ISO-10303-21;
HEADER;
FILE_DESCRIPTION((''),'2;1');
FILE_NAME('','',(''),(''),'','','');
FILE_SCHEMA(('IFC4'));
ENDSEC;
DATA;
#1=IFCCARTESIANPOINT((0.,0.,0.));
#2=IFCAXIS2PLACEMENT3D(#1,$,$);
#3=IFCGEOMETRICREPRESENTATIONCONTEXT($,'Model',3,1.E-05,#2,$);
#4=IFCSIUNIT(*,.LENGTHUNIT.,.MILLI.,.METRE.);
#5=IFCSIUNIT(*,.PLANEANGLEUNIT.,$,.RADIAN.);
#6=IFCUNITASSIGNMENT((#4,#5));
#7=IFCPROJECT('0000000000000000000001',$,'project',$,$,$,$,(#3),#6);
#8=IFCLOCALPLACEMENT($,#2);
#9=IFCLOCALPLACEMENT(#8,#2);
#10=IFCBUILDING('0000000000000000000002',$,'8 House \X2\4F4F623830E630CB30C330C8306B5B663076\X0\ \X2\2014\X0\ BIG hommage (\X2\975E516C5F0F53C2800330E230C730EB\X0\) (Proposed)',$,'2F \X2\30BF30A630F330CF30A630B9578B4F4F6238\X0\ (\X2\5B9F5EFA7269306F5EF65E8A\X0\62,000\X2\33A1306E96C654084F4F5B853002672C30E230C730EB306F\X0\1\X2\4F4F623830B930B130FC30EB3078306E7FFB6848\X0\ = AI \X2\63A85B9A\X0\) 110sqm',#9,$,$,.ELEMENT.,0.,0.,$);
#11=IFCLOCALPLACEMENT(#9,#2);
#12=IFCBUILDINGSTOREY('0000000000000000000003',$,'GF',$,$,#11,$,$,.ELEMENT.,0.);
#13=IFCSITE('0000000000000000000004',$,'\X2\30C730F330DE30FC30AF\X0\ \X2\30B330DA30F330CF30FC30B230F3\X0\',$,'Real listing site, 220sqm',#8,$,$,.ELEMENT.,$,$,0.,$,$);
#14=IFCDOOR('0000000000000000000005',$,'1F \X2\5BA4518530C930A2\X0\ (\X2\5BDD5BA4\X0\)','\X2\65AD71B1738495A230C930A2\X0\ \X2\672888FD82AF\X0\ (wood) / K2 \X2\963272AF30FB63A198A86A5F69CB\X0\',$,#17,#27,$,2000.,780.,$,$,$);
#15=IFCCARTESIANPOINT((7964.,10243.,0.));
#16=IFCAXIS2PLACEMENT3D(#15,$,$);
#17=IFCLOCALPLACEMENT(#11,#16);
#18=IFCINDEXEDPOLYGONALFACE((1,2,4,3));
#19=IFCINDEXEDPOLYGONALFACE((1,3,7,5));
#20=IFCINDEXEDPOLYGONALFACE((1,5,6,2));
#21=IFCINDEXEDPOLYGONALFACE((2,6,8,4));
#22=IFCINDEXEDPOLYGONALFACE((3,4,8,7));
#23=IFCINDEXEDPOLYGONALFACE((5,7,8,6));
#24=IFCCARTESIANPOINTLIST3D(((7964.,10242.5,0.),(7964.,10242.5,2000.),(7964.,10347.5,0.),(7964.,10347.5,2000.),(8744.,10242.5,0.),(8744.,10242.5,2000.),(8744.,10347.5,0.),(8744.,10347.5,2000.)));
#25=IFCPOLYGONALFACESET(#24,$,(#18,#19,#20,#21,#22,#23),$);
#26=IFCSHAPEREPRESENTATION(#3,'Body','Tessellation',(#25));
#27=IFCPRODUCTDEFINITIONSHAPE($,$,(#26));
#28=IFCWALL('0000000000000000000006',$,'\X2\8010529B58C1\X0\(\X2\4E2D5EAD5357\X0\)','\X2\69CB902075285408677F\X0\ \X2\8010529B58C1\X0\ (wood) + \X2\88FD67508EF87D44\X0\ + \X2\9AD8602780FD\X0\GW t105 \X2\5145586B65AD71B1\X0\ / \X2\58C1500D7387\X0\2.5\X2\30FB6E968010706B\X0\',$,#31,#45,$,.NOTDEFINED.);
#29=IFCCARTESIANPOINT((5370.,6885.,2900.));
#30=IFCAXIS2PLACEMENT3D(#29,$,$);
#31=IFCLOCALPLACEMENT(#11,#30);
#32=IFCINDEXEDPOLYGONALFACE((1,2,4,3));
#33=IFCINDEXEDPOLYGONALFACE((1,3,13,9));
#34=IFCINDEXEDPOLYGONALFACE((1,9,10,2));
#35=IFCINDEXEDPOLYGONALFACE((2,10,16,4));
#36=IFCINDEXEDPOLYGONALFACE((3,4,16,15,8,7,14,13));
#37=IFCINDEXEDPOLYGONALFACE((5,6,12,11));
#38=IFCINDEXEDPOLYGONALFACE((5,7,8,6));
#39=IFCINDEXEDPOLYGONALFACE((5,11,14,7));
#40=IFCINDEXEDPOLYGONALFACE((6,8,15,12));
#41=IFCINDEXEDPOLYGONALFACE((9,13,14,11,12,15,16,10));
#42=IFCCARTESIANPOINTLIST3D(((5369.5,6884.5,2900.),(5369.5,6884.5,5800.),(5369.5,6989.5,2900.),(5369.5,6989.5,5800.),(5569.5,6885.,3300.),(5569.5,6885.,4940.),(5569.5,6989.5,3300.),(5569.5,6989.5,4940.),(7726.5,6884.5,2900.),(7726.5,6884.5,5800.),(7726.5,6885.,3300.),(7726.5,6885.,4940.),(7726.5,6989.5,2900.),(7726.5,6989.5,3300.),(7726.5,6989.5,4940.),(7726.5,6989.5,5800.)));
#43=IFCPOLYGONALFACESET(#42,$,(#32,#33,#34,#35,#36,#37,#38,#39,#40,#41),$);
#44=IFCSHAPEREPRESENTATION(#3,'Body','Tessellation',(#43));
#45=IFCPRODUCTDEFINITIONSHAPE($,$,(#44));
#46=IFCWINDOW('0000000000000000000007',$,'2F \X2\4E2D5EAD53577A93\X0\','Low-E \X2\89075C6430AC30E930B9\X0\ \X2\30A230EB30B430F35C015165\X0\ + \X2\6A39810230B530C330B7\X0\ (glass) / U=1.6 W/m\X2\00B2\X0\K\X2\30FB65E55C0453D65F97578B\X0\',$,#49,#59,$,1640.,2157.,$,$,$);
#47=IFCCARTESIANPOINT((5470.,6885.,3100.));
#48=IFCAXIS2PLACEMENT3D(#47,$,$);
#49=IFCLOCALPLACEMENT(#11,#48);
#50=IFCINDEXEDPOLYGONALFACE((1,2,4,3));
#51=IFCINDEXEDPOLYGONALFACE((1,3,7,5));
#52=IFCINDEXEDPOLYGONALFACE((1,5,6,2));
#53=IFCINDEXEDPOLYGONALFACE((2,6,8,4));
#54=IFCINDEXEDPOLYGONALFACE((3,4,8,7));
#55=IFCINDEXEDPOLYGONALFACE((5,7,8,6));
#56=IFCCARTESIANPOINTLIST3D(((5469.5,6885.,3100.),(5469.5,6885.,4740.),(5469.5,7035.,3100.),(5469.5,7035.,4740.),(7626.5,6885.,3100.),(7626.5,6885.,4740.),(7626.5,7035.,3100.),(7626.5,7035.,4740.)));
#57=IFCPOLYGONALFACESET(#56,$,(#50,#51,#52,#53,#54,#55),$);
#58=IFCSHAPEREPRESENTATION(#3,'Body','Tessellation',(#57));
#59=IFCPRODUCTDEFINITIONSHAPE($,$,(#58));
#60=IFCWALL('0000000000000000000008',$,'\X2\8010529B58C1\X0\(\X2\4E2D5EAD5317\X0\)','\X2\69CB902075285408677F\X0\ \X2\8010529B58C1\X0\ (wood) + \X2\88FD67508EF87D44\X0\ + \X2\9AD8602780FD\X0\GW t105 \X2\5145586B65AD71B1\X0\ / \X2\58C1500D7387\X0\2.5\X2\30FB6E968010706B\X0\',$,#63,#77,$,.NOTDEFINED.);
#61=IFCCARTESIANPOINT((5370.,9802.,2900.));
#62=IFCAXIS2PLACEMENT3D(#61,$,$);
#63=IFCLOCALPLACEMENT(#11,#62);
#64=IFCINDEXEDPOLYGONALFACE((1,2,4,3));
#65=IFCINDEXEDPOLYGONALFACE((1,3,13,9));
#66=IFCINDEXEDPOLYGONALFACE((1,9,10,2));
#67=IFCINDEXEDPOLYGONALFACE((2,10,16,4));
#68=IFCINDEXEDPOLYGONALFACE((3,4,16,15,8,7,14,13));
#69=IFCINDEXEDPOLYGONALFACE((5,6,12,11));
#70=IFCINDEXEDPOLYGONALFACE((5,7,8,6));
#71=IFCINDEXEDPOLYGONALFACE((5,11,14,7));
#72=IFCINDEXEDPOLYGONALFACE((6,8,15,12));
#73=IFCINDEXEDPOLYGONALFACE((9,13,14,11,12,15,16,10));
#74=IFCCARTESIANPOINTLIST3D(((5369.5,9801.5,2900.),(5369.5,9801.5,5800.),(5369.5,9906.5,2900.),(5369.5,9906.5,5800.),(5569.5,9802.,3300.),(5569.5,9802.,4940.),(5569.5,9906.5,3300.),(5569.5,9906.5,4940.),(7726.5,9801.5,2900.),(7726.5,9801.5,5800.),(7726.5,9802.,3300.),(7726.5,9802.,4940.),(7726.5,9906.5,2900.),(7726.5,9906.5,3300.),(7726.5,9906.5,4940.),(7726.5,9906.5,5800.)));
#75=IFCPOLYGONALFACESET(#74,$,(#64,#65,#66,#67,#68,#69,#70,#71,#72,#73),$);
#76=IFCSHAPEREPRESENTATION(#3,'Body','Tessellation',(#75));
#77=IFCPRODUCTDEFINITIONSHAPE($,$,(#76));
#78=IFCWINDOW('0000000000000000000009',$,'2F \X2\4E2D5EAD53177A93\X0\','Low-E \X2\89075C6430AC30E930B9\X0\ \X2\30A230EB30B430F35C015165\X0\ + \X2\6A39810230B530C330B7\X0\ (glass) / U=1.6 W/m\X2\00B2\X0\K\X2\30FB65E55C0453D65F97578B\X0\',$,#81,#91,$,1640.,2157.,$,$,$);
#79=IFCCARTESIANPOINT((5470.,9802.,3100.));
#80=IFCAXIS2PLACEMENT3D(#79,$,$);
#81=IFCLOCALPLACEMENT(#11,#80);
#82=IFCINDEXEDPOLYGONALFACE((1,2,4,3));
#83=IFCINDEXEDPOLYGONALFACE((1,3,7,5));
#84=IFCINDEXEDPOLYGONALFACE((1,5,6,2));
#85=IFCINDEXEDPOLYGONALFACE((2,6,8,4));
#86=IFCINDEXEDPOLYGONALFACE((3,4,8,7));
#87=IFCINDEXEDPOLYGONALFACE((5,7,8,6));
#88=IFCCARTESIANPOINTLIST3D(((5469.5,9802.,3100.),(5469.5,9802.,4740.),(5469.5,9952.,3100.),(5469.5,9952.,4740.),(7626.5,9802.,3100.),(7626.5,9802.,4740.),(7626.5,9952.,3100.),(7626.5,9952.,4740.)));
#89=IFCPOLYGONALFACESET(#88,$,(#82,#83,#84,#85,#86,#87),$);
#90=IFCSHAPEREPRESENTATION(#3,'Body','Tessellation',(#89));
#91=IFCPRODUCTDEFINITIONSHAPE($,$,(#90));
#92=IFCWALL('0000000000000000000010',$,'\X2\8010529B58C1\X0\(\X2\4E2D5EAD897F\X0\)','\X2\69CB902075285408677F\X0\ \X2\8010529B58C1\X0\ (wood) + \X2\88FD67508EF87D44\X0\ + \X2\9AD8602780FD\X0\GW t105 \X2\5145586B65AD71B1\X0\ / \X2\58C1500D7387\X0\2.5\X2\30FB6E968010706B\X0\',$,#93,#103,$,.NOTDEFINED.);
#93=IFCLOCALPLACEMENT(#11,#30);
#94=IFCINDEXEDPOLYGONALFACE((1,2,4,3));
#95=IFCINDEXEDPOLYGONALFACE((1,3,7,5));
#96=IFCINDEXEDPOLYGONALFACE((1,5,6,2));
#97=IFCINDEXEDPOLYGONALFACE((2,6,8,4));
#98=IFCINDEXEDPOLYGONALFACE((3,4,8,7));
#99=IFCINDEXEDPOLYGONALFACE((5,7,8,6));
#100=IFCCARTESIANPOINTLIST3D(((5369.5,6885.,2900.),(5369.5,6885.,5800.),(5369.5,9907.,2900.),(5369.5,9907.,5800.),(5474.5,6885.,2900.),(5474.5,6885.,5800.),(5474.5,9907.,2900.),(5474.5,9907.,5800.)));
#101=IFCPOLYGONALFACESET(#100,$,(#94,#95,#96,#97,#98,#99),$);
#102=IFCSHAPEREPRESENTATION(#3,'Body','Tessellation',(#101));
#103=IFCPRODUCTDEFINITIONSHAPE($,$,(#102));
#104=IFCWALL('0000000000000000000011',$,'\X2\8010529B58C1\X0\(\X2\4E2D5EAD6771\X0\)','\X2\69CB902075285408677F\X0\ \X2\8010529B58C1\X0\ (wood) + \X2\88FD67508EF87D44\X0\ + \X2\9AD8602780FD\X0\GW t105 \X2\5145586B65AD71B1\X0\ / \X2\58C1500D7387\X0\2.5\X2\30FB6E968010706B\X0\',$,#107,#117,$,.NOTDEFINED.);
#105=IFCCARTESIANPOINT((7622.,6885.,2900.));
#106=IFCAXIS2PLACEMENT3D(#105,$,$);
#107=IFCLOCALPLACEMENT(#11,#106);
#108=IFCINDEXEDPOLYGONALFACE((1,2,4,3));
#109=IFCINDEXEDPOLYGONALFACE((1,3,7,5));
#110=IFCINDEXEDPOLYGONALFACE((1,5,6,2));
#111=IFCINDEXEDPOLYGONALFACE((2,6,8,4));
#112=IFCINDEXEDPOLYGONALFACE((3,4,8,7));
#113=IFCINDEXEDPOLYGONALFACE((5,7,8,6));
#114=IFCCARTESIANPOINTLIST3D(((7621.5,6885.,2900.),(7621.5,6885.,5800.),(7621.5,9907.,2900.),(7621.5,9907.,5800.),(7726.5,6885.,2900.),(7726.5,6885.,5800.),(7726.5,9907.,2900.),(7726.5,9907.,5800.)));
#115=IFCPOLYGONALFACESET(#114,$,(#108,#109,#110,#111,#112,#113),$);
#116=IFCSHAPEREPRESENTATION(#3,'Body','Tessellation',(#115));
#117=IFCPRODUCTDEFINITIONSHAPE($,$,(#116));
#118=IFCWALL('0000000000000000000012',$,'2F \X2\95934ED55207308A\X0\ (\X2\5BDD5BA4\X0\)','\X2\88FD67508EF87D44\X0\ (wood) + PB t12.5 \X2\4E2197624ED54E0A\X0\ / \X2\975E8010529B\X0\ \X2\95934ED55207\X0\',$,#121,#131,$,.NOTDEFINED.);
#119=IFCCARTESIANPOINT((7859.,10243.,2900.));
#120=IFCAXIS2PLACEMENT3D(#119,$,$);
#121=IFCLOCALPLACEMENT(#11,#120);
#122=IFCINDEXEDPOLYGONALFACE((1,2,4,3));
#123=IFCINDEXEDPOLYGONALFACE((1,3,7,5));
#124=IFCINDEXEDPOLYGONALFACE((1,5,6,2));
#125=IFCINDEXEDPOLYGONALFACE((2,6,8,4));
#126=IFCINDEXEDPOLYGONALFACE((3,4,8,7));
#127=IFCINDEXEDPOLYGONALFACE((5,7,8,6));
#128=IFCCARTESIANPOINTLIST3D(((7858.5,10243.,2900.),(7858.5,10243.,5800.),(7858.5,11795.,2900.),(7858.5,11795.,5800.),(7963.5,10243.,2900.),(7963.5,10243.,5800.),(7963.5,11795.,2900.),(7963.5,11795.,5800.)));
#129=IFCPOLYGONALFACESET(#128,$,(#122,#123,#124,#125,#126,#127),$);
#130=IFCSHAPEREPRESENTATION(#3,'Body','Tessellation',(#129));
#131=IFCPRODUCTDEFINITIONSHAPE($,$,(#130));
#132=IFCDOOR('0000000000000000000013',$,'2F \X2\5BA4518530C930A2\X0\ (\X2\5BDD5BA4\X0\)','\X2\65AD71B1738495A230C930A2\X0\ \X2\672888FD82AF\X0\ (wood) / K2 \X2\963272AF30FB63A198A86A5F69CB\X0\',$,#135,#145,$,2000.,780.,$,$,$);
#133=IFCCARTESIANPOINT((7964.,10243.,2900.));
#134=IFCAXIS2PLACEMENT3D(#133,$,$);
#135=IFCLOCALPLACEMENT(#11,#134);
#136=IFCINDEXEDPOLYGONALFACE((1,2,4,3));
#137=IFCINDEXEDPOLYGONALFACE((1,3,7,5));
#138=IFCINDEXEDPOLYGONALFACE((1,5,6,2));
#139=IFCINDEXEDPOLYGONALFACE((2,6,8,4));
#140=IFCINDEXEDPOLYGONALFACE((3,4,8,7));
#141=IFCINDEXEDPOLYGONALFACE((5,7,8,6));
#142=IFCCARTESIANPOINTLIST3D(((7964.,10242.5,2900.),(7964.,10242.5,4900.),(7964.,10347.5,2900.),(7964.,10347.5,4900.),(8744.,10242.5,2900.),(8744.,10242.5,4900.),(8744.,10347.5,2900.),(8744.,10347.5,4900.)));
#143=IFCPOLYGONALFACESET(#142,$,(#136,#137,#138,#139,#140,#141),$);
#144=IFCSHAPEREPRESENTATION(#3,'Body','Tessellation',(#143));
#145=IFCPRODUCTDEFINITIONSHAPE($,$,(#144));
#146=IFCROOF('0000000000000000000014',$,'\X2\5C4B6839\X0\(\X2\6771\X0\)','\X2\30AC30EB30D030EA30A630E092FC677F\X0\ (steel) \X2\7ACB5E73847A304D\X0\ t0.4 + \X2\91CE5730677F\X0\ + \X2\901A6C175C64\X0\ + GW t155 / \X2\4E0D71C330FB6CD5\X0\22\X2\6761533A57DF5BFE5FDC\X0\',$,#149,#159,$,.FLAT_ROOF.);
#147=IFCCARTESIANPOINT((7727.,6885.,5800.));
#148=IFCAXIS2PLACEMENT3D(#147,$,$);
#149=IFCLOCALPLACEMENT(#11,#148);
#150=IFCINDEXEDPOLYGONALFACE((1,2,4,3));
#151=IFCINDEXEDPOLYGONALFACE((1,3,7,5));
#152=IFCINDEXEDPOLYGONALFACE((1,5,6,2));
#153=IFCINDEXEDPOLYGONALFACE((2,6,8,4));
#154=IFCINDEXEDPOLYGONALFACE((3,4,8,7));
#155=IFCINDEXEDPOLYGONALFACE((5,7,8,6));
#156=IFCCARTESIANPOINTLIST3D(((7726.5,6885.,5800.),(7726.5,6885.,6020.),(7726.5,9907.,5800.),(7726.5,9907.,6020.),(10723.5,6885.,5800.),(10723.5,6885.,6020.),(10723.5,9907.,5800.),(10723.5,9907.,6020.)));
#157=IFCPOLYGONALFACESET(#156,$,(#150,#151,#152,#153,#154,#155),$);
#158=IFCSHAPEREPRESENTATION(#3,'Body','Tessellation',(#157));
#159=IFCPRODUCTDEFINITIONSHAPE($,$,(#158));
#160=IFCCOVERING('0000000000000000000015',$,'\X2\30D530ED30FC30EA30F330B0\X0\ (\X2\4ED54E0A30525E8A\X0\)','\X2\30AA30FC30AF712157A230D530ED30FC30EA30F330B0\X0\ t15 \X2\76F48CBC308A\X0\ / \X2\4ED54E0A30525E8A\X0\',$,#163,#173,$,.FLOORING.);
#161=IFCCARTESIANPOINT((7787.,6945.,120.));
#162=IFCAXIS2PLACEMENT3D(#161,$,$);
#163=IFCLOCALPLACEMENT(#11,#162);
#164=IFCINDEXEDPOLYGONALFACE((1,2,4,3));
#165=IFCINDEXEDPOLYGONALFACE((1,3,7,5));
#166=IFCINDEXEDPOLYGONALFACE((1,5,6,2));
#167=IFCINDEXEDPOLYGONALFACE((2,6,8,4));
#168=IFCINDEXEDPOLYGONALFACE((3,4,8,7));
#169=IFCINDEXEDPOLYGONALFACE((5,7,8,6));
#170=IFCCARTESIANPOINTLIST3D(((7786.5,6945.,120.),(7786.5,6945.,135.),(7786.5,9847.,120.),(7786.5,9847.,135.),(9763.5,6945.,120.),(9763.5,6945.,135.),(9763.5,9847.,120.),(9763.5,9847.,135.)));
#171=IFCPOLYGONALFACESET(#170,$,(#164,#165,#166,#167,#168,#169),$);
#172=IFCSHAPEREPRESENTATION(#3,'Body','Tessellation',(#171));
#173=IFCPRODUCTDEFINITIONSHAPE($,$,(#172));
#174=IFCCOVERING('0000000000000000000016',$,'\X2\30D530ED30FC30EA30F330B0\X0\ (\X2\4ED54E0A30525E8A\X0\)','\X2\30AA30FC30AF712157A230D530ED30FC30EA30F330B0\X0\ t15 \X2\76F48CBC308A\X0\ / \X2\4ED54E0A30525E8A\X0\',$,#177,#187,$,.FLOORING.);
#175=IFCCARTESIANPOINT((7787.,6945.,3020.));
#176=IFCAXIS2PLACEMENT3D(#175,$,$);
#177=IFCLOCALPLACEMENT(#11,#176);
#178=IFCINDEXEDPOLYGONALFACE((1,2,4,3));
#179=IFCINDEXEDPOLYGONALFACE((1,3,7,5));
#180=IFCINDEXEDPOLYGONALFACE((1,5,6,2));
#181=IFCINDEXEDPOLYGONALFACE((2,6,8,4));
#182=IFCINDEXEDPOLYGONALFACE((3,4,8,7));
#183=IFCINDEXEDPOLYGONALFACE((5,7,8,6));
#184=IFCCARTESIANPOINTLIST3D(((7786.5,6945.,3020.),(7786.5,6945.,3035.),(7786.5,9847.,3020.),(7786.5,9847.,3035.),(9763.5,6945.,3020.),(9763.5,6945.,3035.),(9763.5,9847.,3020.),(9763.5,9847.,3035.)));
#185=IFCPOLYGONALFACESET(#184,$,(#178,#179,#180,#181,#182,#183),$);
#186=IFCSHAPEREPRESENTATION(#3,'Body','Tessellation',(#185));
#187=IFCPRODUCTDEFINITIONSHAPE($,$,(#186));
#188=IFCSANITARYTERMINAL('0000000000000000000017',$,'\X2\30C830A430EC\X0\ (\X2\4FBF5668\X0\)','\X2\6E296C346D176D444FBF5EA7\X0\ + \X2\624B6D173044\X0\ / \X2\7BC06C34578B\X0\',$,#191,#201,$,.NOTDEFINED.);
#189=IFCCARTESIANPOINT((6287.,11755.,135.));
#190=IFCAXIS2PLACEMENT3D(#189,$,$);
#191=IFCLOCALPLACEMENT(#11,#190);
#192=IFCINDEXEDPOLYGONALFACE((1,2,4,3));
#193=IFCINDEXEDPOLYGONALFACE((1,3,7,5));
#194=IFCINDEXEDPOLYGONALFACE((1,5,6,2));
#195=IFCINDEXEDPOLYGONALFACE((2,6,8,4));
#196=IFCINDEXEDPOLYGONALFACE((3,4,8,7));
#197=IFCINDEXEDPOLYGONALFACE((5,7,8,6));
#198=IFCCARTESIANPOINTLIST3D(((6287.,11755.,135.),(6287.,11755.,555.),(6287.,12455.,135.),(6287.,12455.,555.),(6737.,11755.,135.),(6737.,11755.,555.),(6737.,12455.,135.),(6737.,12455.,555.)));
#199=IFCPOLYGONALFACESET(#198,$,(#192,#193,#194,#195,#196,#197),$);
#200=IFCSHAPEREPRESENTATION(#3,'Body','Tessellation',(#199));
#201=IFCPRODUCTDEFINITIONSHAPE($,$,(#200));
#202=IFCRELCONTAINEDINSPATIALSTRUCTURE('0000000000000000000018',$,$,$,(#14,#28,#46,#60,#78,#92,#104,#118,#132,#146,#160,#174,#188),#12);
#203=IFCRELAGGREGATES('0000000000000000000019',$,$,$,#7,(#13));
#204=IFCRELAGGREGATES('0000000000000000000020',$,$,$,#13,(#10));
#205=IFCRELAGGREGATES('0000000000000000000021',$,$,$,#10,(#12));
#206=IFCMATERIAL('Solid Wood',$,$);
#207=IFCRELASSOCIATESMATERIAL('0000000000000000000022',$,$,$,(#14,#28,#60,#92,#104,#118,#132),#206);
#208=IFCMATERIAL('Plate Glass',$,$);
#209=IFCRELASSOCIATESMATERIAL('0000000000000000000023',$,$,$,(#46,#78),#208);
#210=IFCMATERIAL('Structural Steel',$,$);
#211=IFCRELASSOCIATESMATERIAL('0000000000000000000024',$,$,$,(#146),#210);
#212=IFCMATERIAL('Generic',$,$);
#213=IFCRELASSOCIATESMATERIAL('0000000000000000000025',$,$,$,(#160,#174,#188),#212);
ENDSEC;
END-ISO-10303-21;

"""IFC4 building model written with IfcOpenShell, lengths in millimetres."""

from ifc_helpers import new_model, si_unit, frame, frame_2d, origin, place, context, project, spatial, rectangle, extrude, material, element, fill, save


model = new_model("IFC4")

# Units and contexts
model_context = context("Model", 3, precision=1e-05, world=origin())
ifc_project = project(units=[si_unit("LENGTHUNIT", "METRE", prefix="MILLI"), si_unit("PLANEANGLEUNIT", "RADIAN")], contexts=[model_context])

# Site, building, storey
site_placement = place(None, origin())
site = spatial("IfcSite", under=ifc_project, at=site_placement, Name="デンマーク コペンハーゲン", ObjectType="Real listing site, 220sqm", CompositionType="ELEMENT", RefElevation=0.0)
building_placement = place(site_placement, origin())
building = spatial("IfcBuilding", under=site, at=building_placement, Name="8 House 住戸ユニットに学ぶ — BIG hommage (非公式参考モデル) (Proposed)", ObjectType="2F タウンハウス型住戸 (実建物は延床62,000㎡の集合住宅。本モデルは1住戸スケールへの翻案 = AI 推定) 110sqm", CompositionType="ELEMENT", ElevationOfRefHeight=0.0, ElevationOfTerrain=0.0)
storey_placement = place(building_placement, origin())
storey = spatial("IfcBuildingStorey", under=building, at=storey_placement, Name="GF", CompositionType="ELEMENT", Elevation=0.0)

# Shared definitions
ifc_material_1 = material(Name="Solid Wood")

# Shared definitions
ifc_material_2 = material(Name="Plate Glass")

# Door
door_1_placement = place(storey_placement, frame((7964.0, 10243.0, 0.0)))
element("IfcDoor", 1, at=door_1_placement, inside=storey, material=ifc_material_1, Name="1F 室内ドア (寝室)", Description="断熱玄関ドア 木製芯 (wood) / K2 防犯・採風機構", OverallHeight=2000.0, OverallWidth=780.0, context=model_context, shape_type="SweptSolid", body=[
    extrude(rectangle(XDim=780.0, YDim=105.0, at=frame_2d((390.0, 52.0))), frame((7964.0, 10243.0, 0.0)), (0.0, 0.0, 1.0), 2000.0),
])

# Walls, openings, windows
wall_1_placement = place(storey_placement, frame((5370.0, 6885.0, 2900.0)))
wall_1 = element("IfcWall", 2, at=wall_1_placement, inside=storey, material=ifc_material_1, Name="耐力壁(中庭南)", Description="構造用合板 耐力壁 (wood) + 製材軸組 + 高性能GW t105 充填断熱 / 壁倍率2.5・準耐火", PredefinedType="NOTDEFINED", context=model_context, shape_type="SweptSolid", body=[
    extrude(rectangle(XDim=2357.0, YDim=105.0, at=frame_2d((1178.0, 52.0))), frame((5370.0, 6885.0, 2900.0)), (0.0, 0.0, 1.0), 2900.0),
])
opening_1_placement = place(storey_placement, frame((5470.0, 6885.0, 3100.0)))
opening_1 = element("IfcOpeningElement", 3, at=opening_1_placement, cuts=wall_1, PredefinedType="NOTDEFINED", context=model_context, shape_type="SweptSolid", body=[
    extrude(rectangle(XDim=2157.0, YDim=150.0, at=frame_2d((1078.0, 75.0))), frame((5470.0, 6885.0, 3100.0)), (0.0, 0.0, 1.0), 1640.0),
])
window_1_placement = place(storey_placement, frame((5470.0, 6885.0, 3100.0)))
window_1 = element("IfcWindow", 4, at=window_1_placement, inside=storey, material=ifc_material_2, Name="2F 中庭南窓", Description="Low-E 複層ガラス アルゴン封入 + 樹脂サッシ (glass) / U=1.6 W/m²K・日射取得型", OverallHeight=1640.0, OverallWidth=2157.0, context=model_context, shape_type="SweptSolid", body=[
    extrude(rectangle(XDim=2157.0, YDim=150.0, at=frame_2d((1078.0, 75.0))), frame((5470.0, 6885.0, 3100.0)), (0.0, 0.0, 1.0), 1640.0),
])
fill(opening_1, window_1)
wall_2_placement = place(storey_placement, frame((5370.0, 9802.0, 2900.0)))
wall_2 = element("IfcWall", 5, at=wall_2_placement, inside=storey, material=ifc_material_1, Name="耐力壁(中庭北)", Description="構造用合板 耐力壁 (wood) + 製材軸組 + 高性能GW t105 充填断熱 / 壁倍率2.5・準耐火", PredefinedType="NOTDEFINED", context=model_context, shape_type="SweptSolid", body=[
    extrude(rectangle(XDim=2357.0, YDim=105.0, at=frame_2d((1178.0, 52.0))), frame((5370.0, 9802.0, 2900.0)), (0.0, 0.0, 1.0), 2900.0),
])
opening_2_placement = place(storey_placement, frame((5470.0, 9802.0, 3100.0)))
opening_2 = element("IfcOpeningElement", 6, at=opening_2_placement, cuts=wall_2, PredefinedType="NOTDEFINED", context=model_context, shape_type="SweptSolid", body=[
    extrude(rectangle(XDim=2157.0, YDim=150.0, at=frame_2d((1078.0, 75.0))), frame((5470.0, 9802.0, 3100.0)), (0.0, 0.0, 1.0), 1640.0),
])
window_2_placement = place(storey_placement, frame((5470.0, 9802.0, 3100.0)))
window_2 = element("IfcWindow", 7, at=window_2_placement, inside=storey, material=ifc_material_2, Name="2F 中庭北窓", Description="Low-E 複層ガラス アルゴン封入 + 樹脂サッシ (glass) / U=1.6 W/m²K・日射取得型", OverallHeight=1640.0, OverallWidth=2157.0, context=model_context, shape_type="SweptSolid", body=[
    extrude(rectangle(XDim=2157.0, YDim=150.0, at=frame_2d((1078.0, 75.0))), frame((5470.0, 9802.0, 3100.0)), (0.0, 0.0, 1.0), 1640.0),
])
fill(opening_2, window_2)

# Walls
wall_3_placement = place(storey_placement, frame((5370.0, 6885.0, 2900.0)))
element("IfcWall", 8, at=wall_3_placement, inside=storey, material=ifc_material_1, Name="耐力壁(中庭西)", Description="構造用合板 耐力壁 (wood) + 製材軸組 + 高性能GW t105 充填断熱 / 壁倍率2.5・準耐火", PredefinedType="NOTDEFINED", context=model_context, shape_type="SweptSolid", body=[
    extrude(rectangle(XDim=105.0, YDim=3022.0, at=frame_2d((52.0, 1511.0))), frame((5370.0, 6885.0, 2900.0)), (0.0, 0.0, 1.0), 2900.0),
])
wall_4_placement = place(storey_placement, frame((7622.0, 6885.0, 2900.0)))
element("IfcWall", 9, at=wall_4_placement, inside=storey, material=ifc_material_1, Name="耐力壁(中庭東)", Description="構造用合板 耐力壁 (wood) + 製材軸組 + 高性能GW t105 充填断熱 / 壁倍率2.5・準耐火", PredefinedType="NOTDEFINED", context=model_context, shape_type="SweptSolid", body=[
    extrude(rectangle(XDim=105.0, YDim=3022.0, at=frame_2d((52.0, 1511.0))), frame((7622.0, 6885.0, 2900.0)), (0.0, 0.0, 1.0), 2900.0),
])
wall_5_placement = place(storey_placement, frame((7859.0, 10243.0, 2900.0)))
element("IfcWall", 10, at=wall_5_placement, inside=storey, material=ifc_material_1, Name="2F 間仕切り (寝室)", Description="製材軸組 (wood) + PB t12.5 両面仕上 / 非耐力 間仕切", PredefinedType="NOTDEFINED", context=model_context, shape_type="SweptSolid", body=[
    extrude(rectangle(XDim=105.0, YDim=1552.0, at=frame_2d((52.0, 776.0))), frame((7859.0, 10243.0, 2900.0)), (0.0, 0.0, 1.0), 2900.0),
])

# Door
door_2_placement = place(storey_placement, frame((7964.0, 10243.0, 2900.0)))
element("IfcDoor", 11, at=door_2_placement, inside=storey, material=ifc_material_1, Name="2F 室内ドア (寝室)", Description="断熱玄関ドア 木製芯 (wood) / K2 防犯・採風機構", OverallHeight=2000.0, OverallWidth=780.0, context=model_context, shape_type="SweptSolid", body=[
    extrude(rectangle(XDim=780.0, YDim=105.0, at=frame_2d((390.0, 52.0))), frame((7964.0, 10243.0, 2900.0)), (0.0, 0.0, 1.0), 2000.0),
])

# Roof
ifc_material_3 = material(Name="Structural Steel")
roof_placement = place(storey_placement, frame((7727.0, 6885.0, 5800.0)))
element("IfcRoof", 12, at=roof_placement, inside=storey, material=ifc_material_3, Name="屋根(東)", Description="ガルバリウム鋼板 (steel) 立平葺き t0.4 + 野地板 + 通気層 + GW t155 / 不燃・法22条区域対応", PredefinedType="FLAT_ROOF", context=model_context, shape_type="SweptSolid", body=[
    extrude(rectangle(XDim=2997.0, YDim=3022.0, at=frame_2d((1498.0, 1511.0))), frame((7727.0, 6885.0, 5800.0)), (0.0, 0.0, 1.0), 220.0),
])

# Coverings
ifc_material_4 = material(Name="Generic")
covering_1_placement = place(storey_placement, frame((7787.0, 6945.0, 120.0)))
element("IfcCovering", 13, at=covering_1_placement, inside=storey, material=ifc_material_4, Name="フローリング (仕上げ床)", Description="オーク無垢フローリング t15 直貼り / 仕上げ床", PredefinedType="FLOORING", context=model_context, shape_type="SweptSolid", body=[
    extrude(rectangle(XDim=1977.0, YDim=2902.0, at=frame_2d((988.0, 1451.0))), frame((7787.0, 6945.0, 120.0)), (0.0, 0.0, 1.0), 15.0),
])
covering_2_placement = place(storey_placement, frame((7787.0, 6945.0, 3020.0)))
element("IfcCovering", 14, at=covering_2_placement, inside=storey, material=ifc_material_4, Name="フローリング (仕上げ床)", Description="オーク無垢フローリング t15 直貼り / 仕上げ床", PredefinedType="FLOORING", context=model_context, shape_type="SweptSolid", body=[
    extrude(rectangle(XDim=1977.0, YDim=2902.0, at=frame_2d((988.0, 1451.0))), frame((7787.0, 6945.0, 3020.0)), (0.0, 0.0, 1.0), 15.0),
])

# Sanitary terminal
sanitary_terminal_placement = place(storey_placement, frame((6287.0, 11755.0, 135.0)))
element("IfcSanitaryTerminal", 15, at=sanitary_terminal_placement, inside=storey, material=ifc_material_4, Name="トイレ (便器)", Description="温水洗浄便座 + 手洗い / 節水型", PredefinedType="NOTDEFINED", context=model_context, shape_type="SweptSolid", body=[
    extrude(rectangle(XDim=450.0, YDim=700.0, at=frame_2d((225.0, 350.0))), frame((6287.0, 11755.0, 135.0)), (0.0, 0.0, 1.0), 420.0),
])

save(model, "model.ifc")
